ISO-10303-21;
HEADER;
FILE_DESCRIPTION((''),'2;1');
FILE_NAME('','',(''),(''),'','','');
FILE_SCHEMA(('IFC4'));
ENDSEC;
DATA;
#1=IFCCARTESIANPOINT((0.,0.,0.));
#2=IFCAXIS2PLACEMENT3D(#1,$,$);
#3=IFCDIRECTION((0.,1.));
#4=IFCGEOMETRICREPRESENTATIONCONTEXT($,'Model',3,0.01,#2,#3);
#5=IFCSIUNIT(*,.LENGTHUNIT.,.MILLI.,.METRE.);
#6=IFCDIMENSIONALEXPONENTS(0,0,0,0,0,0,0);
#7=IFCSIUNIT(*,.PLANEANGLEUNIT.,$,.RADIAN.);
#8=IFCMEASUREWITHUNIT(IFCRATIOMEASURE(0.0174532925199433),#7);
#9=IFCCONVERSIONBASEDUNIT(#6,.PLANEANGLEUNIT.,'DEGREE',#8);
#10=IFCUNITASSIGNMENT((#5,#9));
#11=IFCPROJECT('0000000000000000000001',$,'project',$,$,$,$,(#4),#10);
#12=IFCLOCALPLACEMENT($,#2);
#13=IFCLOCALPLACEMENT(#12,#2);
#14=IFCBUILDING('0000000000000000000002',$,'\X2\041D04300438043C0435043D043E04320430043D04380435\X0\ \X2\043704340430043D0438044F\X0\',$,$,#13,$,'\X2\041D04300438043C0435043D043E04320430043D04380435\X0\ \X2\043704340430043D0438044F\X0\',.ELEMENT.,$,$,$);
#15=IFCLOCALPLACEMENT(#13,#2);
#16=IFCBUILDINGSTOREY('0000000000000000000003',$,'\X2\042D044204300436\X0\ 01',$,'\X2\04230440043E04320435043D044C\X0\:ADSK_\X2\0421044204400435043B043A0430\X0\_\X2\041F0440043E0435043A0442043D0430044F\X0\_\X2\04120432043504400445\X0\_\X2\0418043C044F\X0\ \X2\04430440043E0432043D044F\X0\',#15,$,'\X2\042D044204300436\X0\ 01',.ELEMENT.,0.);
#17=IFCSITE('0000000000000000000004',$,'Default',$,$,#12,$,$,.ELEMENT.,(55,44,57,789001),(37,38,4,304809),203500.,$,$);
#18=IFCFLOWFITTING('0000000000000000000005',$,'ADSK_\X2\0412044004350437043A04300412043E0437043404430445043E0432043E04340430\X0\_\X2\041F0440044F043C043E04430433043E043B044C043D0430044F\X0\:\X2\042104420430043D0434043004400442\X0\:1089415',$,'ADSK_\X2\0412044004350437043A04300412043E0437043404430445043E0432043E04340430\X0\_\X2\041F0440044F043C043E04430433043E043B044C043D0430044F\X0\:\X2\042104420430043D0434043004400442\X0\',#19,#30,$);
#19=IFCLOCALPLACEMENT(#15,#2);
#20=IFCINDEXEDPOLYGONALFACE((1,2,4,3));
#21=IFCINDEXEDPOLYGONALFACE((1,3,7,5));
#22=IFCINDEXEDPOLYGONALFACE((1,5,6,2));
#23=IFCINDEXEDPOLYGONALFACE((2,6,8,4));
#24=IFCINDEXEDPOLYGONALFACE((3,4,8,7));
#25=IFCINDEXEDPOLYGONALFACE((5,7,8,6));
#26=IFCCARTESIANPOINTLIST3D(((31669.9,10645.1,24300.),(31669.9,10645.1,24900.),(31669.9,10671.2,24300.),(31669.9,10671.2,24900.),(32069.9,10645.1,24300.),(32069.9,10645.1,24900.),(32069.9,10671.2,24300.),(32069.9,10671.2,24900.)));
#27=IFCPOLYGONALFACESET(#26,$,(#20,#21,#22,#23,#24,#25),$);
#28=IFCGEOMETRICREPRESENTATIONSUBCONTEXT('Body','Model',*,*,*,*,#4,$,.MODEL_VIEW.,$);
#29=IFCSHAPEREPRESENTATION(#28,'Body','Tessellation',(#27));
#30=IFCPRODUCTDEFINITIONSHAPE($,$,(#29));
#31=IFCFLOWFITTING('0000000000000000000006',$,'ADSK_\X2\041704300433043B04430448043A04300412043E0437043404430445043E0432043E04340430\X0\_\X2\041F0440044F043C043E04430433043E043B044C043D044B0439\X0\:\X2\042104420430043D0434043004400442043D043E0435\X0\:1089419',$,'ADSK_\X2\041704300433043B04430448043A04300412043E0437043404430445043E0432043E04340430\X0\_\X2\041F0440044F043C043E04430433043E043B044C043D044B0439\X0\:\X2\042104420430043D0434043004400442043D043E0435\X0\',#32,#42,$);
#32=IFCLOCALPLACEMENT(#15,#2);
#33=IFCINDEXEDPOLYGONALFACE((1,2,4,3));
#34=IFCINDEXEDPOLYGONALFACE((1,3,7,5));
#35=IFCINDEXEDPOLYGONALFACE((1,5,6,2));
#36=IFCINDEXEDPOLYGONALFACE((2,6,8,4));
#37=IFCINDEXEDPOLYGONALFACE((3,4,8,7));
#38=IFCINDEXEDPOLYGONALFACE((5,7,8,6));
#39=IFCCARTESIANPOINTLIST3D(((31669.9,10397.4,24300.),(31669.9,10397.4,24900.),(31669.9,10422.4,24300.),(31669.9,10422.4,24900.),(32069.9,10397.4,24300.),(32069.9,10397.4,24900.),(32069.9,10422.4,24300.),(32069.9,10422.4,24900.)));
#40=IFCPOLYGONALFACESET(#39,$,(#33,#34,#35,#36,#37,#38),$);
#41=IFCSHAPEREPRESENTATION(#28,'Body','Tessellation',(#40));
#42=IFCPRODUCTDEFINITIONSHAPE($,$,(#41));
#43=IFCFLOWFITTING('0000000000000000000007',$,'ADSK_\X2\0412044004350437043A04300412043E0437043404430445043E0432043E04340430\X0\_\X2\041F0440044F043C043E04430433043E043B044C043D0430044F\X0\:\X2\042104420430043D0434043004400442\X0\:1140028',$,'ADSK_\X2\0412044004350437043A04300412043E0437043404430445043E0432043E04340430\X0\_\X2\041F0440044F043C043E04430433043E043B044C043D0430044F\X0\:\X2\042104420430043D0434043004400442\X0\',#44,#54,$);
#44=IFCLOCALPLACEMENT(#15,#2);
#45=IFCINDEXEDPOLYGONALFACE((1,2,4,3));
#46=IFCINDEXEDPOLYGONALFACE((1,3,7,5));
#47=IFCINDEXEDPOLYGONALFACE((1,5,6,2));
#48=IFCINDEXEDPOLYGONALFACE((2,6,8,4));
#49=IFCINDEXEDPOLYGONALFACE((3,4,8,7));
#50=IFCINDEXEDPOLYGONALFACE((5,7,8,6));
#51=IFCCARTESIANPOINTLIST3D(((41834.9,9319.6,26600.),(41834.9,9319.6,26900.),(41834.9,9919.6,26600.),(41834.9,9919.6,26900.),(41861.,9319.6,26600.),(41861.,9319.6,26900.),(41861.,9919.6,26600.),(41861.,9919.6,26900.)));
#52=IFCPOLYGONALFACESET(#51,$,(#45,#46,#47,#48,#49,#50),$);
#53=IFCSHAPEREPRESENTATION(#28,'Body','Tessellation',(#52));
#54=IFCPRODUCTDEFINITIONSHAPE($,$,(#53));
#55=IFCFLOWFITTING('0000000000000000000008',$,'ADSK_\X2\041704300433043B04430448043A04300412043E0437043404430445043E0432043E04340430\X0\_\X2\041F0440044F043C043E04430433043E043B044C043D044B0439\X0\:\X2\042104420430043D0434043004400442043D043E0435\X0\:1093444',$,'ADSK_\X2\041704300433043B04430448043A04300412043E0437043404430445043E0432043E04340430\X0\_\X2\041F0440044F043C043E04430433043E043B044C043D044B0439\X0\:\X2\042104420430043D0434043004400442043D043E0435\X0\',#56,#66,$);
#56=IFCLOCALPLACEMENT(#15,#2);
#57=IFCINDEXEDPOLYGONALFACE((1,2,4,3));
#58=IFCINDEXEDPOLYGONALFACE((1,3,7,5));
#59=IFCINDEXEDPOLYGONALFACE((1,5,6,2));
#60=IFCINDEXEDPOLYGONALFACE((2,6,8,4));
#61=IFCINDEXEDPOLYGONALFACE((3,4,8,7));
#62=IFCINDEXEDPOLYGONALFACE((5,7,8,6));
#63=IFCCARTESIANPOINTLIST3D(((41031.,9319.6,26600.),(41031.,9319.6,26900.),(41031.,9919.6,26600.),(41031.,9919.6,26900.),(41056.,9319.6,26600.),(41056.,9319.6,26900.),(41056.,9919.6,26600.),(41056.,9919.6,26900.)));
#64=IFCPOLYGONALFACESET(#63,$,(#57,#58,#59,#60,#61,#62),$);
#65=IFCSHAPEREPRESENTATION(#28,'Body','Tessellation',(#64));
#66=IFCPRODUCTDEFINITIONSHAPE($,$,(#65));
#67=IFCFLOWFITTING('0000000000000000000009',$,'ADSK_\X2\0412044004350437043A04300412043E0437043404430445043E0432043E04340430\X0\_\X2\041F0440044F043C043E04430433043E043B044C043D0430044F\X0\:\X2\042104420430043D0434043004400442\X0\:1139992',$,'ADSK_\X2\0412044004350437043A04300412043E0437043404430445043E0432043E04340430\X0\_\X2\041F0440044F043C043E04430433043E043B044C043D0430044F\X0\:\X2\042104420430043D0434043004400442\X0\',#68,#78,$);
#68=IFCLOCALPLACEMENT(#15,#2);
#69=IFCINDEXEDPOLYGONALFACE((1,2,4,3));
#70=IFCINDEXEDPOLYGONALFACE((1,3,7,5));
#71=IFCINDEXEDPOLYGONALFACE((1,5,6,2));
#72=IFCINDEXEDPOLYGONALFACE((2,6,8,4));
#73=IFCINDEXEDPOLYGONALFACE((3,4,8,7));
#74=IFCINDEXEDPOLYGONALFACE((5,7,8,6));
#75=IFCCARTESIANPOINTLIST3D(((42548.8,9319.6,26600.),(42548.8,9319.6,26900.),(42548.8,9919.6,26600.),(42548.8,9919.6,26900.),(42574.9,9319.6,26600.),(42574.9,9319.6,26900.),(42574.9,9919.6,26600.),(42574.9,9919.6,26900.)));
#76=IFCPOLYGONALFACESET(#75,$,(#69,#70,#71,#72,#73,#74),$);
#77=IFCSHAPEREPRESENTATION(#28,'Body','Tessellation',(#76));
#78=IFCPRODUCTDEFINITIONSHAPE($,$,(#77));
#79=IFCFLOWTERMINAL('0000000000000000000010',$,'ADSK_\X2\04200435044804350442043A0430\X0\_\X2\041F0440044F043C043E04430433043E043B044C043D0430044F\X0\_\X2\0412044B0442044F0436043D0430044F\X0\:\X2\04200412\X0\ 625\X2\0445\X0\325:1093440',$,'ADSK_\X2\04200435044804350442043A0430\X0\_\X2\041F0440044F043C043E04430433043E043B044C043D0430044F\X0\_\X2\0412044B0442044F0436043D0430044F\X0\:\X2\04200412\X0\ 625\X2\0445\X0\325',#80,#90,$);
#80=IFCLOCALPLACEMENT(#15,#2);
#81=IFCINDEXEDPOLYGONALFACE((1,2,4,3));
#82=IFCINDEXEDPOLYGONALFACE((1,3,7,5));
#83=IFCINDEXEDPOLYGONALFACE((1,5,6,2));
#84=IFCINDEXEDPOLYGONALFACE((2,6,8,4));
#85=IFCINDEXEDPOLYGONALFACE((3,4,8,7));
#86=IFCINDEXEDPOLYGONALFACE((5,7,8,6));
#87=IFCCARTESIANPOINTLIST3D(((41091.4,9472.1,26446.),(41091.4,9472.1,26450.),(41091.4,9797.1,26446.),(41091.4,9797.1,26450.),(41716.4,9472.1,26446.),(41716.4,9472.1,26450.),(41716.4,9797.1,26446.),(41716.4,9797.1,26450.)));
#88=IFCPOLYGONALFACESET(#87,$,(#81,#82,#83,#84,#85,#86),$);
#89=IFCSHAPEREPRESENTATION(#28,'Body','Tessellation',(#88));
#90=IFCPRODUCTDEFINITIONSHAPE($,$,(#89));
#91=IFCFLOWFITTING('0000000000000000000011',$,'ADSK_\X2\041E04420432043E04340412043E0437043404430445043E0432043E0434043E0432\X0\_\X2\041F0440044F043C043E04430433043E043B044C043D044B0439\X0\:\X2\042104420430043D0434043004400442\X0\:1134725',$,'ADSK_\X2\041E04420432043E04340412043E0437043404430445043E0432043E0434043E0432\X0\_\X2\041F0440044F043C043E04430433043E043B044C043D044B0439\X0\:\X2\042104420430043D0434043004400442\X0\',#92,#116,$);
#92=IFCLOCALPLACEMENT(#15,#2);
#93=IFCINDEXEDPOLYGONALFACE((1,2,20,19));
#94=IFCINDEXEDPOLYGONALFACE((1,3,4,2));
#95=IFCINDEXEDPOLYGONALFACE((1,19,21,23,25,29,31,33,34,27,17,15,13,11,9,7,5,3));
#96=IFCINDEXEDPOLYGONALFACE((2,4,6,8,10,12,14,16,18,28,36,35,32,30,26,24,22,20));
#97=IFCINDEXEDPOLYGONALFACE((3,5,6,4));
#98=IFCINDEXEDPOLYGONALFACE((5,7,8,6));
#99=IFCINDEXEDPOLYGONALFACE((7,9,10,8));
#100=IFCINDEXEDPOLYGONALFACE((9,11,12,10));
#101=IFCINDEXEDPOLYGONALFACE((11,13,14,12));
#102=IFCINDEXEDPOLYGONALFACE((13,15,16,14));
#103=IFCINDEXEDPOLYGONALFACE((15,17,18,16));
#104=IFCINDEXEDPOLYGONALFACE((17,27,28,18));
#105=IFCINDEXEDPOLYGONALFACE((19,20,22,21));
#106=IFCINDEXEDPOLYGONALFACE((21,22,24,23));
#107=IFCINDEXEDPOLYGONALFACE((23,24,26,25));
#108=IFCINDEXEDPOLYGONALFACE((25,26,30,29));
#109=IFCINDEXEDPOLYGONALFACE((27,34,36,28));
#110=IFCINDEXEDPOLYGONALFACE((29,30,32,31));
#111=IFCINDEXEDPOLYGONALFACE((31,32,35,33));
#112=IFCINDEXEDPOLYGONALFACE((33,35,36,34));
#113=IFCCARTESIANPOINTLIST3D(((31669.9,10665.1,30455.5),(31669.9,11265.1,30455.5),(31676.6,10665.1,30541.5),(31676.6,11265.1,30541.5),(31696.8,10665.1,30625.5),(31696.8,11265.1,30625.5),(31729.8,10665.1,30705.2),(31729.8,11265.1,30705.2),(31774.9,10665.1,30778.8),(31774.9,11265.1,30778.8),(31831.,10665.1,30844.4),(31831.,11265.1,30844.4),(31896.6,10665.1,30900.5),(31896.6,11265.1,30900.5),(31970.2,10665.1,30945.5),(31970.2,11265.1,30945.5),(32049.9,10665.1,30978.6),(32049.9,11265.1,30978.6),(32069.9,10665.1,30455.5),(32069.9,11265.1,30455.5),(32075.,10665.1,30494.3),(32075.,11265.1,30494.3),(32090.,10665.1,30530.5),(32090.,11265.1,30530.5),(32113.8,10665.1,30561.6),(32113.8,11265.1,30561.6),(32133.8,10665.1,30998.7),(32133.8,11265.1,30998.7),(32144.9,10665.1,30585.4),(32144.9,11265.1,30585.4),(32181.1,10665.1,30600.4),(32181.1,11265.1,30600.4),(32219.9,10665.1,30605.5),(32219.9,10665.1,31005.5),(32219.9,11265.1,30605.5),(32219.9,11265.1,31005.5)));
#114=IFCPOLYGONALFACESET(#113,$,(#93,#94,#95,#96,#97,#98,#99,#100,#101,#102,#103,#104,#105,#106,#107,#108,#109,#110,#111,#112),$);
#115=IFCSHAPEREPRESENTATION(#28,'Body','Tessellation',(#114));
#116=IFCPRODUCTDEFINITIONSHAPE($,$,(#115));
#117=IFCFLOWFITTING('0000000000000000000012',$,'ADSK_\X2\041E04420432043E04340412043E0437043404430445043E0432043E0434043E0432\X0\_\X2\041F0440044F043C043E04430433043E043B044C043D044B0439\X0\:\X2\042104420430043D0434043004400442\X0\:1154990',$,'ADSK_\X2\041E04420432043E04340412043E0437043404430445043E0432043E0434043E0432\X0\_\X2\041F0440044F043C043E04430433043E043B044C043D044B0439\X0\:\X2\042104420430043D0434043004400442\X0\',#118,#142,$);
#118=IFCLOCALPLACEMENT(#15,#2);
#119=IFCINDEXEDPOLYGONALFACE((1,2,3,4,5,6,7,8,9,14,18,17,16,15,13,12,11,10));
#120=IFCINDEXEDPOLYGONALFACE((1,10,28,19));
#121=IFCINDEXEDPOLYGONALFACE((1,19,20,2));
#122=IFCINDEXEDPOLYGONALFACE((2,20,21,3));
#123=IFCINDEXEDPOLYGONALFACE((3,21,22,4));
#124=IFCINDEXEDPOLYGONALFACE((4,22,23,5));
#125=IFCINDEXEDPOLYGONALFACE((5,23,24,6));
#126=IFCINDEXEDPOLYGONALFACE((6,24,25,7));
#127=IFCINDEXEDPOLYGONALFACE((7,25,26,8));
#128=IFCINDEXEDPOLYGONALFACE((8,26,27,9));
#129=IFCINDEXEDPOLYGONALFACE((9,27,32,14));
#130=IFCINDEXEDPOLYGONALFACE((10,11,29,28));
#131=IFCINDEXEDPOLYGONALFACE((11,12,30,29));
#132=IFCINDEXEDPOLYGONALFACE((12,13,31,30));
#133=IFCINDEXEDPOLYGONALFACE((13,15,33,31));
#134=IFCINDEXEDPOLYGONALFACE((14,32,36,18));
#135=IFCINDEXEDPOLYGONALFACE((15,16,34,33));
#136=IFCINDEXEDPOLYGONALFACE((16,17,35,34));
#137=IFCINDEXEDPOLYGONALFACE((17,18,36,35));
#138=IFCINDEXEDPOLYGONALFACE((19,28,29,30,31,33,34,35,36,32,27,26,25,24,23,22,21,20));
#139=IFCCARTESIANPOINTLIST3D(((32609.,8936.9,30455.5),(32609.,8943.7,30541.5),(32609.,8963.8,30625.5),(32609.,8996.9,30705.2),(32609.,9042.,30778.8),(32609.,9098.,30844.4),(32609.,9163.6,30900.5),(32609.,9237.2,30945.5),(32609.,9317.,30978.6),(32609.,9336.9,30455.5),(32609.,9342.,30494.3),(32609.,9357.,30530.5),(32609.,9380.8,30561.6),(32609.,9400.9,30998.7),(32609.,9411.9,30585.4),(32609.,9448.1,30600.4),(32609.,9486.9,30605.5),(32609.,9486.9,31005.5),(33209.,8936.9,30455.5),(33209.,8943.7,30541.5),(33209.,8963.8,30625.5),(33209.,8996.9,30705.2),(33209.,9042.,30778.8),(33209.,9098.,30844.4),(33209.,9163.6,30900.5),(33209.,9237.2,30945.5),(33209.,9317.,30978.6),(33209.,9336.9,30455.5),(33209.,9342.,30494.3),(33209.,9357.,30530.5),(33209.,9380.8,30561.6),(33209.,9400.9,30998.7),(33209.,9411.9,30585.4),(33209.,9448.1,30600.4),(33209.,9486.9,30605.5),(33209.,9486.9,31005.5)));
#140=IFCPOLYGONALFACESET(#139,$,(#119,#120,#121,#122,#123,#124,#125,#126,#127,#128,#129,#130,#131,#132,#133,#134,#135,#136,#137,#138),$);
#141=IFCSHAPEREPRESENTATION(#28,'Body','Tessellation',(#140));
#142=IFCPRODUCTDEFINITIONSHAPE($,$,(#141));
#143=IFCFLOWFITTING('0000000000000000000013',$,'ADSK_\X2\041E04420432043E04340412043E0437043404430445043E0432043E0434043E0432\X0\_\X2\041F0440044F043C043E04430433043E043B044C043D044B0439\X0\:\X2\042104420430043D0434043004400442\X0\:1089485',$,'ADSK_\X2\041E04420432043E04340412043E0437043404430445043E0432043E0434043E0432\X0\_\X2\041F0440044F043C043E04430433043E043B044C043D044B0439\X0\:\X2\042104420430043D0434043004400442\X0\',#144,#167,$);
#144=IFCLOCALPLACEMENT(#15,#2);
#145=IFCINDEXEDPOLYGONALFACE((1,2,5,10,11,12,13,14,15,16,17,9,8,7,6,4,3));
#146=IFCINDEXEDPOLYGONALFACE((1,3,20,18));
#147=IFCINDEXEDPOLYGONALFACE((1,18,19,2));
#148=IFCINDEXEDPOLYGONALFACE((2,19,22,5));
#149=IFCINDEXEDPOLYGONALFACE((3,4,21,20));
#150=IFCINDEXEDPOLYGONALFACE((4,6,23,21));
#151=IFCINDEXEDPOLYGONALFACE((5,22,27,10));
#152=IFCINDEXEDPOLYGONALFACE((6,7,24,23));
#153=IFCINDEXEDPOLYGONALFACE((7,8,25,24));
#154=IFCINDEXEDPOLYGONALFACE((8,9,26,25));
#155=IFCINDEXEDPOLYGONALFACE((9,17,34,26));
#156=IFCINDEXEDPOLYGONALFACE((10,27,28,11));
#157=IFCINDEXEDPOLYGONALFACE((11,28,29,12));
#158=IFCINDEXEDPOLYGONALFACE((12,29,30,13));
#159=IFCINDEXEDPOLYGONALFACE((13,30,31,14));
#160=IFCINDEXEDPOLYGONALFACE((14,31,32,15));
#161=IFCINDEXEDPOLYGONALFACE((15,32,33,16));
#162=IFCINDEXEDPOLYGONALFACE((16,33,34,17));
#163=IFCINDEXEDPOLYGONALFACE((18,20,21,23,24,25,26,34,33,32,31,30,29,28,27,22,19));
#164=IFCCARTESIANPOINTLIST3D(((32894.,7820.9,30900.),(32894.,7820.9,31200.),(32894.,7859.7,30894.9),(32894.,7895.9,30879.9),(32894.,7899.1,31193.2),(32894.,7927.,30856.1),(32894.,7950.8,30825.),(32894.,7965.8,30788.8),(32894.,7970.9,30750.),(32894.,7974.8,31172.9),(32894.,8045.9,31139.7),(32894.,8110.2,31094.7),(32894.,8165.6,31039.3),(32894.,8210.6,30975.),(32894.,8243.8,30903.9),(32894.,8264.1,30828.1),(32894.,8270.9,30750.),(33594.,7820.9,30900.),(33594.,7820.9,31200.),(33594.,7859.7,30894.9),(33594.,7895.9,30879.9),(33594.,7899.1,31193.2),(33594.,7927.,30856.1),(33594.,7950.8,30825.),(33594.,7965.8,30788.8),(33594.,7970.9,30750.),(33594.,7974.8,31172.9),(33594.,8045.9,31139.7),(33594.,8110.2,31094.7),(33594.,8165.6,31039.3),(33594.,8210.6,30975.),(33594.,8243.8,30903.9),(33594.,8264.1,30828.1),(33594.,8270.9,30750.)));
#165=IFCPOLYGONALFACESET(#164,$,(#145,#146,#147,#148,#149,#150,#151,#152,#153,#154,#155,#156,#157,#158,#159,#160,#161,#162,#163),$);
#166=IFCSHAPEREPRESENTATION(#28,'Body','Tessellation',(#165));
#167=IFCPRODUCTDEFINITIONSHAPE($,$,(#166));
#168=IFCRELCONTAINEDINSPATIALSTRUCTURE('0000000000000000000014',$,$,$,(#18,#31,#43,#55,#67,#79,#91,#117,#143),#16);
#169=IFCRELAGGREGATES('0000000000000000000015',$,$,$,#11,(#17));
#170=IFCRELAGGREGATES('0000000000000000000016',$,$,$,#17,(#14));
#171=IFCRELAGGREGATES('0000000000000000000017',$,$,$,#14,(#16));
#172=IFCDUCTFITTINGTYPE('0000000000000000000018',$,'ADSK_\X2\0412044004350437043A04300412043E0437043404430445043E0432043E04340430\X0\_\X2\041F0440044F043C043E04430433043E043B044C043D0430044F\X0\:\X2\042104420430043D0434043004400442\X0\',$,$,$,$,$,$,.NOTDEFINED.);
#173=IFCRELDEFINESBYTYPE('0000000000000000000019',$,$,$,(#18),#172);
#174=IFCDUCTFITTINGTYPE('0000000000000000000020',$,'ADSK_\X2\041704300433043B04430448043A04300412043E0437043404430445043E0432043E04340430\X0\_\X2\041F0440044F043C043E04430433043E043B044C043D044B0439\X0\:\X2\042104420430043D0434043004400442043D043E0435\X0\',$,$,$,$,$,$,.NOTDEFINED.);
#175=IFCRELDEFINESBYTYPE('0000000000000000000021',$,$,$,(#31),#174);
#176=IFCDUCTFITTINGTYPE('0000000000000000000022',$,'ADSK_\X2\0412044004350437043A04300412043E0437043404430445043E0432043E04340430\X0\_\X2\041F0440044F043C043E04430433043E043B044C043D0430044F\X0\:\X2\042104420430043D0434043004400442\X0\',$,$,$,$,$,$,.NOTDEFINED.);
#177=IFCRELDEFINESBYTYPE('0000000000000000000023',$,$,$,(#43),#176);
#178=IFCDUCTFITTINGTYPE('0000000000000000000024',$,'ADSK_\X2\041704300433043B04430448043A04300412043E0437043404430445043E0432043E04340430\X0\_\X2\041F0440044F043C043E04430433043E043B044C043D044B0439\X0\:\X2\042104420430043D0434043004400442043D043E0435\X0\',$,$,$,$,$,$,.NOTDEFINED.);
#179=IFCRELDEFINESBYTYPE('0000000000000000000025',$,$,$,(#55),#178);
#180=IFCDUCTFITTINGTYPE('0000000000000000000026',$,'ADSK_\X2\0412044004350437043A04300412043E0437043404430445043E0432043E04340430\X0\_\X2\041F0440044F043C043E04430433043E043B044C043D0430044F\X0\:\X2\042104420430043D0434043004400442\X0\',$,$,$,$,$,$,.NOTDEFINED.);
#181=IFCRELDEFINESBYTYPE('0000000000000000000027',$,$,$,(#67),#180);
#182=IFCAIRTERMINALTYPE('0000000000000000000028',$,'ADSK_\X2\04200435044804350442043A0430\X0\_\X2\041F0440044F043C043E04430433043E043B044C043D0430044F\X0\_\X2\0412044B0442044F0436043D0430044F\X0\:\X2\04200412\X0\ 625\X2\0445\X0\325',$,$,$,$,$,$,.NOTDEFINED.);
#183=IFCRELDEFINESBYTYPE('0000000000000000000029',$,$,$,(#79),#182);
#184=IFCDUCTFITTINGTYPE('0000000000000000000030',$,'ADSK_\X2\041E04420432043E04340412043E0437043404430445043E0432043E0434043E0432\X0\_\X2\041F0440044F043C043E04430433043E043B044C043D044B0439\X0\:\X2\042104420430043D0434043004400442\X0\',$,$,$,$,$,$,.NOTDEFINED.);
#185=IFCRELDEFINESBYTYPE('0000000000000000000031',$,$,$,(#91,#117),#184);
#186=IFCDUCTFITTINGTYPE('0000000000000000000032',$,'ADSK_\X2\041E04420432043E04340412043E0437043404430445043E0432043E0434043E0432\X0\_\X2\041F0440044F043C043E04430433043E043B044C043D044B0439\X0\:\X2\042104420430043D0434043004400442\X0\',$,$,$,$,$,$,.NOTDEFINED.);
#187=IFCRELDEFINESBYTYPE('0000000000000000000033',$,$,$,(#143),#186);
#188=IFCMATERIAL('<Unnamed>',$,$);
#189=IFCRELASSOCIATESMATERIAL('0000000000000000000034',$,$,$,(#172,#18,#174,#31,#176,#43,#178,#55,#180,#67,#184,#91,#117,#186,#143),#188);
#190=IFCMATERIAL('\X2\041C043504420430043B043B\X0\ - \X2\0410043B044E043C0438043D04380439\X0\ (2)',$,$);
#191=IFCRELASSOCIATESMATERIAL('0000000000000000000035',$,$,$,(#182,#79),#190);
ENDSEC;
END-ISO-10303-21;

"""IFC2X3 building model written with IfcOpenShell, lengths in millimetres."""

from ifc_helpers import new_model, entity, si_unit, converted_unit, direction, frame, frame_2d, origin, origin_2d_with_axis, place, context, subcontext, project, spatial, polyline, circle_curve, parameter, trimmed, segment, composite_curve, rectangle, outline, extrude, source, transform, mapped, material, type_object, type_shapes, element, save


model = new_model("IFC2X3")

# Units and contexts
model_context = context("Model", 3, precision=0.01, world=origin(), true_north=direction((0.0, 1.0)))
body_context = subcontext(model_context, "Body", "Model", "MODEL_VIEW")
ifc_project = project(units=[si_unit("LENGTHUNIT", "METRE", prefix="MILLI"), converted_unit("PLANEANGLEUNIT", "DEGREE", entity("IfcRatioMeasure", 0.0174532925199433), si_unit("PLANEANGLEUNIT", "RADIAN"), dimensions=[0, 0, 0, 0, 0, 0, 0])], contexts=[model_context])

# Site, building, storey
site_placement = place(None, frame((0.0, 0.0, 0.0)))
site = spatial("IfcSite", under=ifc_project, at=site_placement, Name="Default", CompositionType="ELEMENT", RefLatitude=(55, 44, 57, 789001), RefLongitude=(37, 38, 4, 304809), RefElevation=203500.0)
building_placement = place(site_placement, origin())
building = spatial("IfcBuilding", under=site, at=building_placement, Name="Наименование здания", LongName="Наименование здания", CompositionType="ELEMENT")
storey_placement = place(building_placement, origin())
storey = spatial("IfcBuildingStorey", under=building, at=storey_placement, Name="Этаж 01", ObjectType="Уровень:ADSK_Стрелка_Проектная_Вверх_Имя уровня", LongName="Этаж 01", CompositionType="ELEMENT", Elevation=0.0)

# Flow fittings
ifc_material_1 = material(Name="<Unnamed>")
duct_fitting_type_1 = type_object("IfcDuctFittingType", Name="ADSK_ВрезкаВоздуховода_Прямоугольная:Стандарт", PredefinedType="NOTDEFINED", material=ifc_material_1)
shared_shape_1 = source(origin(), body_context, "Body", "SweptSolid", [
    extrude(rectangle(XDim=26.1, YDim=600.0, at=frame_2d((0.0, 0.0), x_axis=(1.0, 0.0))), frame((7.0, 0.0, -200.0)), (0.0, 0.0, 1.0), 400.0),
])
type_shapes(duct_fitting_type_1, [shared_shape_1])
flow_fitting_1_placement = place(storey_placement, frame((31869.9, 10665.1, 24600.0), z_axis=(-1.0, 0.0, 0.0), x_axis=(0.0, -1.0, 0.0)))
element("IfcFlowFitting", 1, at=flow_fitting_1_placement, inside=storey, type_object=duct_fitting_type_1, material=ifc_material_1, Name="ADSK_ВрезкаВоздуховода_Прямоугольная:Стандарт:1089415", ObjectType="ADSK_ВрезкаВоздуховода_Прямоугольная:Стандарт", context=body_context, shape_type="MappedRepresentation", body=[
    mapped(shared_shape_1, transform((0.0, 0.0, 0.0), scale=1.0)),
])
duct_fitting_type_2 = type_object("IfcDuctFittingType", Name="ADSK_ЗаглушкаВоздуховода_Прямоугольный:Стандартное", PredefinedType="NOTDEFINED", material=ifc_material_1)
shared_shape_2 = source(origin(), body_context, "Body", "SweptSolid", [
    extrude(rectangle(XDim=25.0, YDim=400.0, at=frame_2d((0.0, 0.0), x_axis=(1.0, 0.0))), frame((12.5, 0.0, -300.0)), (0.0, 0.0, 1.0), 600.0),
])
type_shapes(duct_fitting_type_2, [shared_shape_2])
flow_fitting_2_placement = place(storey_placement, frame((31869.9, 10422.4, 24600.0), z_axis=(0.0, 0.0, 1.0), x_axis=(0.0, -1.0, 0.0)))
element("IfcFlowFitting", 2, at=flow_fitting_2_placement, inside=storey, type_object=duct_fitting_type_2, material=ifc_material_1, Name="ADSK_ЗаглушкаВоздуховода_Прямоугольный:Стандартное:1089419", ObjectType="ADSK_ЗаглушкаВоздуховода_Прямоугольный:Стандартное", context=body_context, shape_type="MappedRepresentation", body=[
    mapped(shared_shape_2, transform((0.0, 0.0, 0.0), scale=1.0)),
])
duct_fitting_type_3 = type_object("IfcDuctFittingType", Name="ADSK_ВрезкаВоздуховода_Прямоугольная:Стандарт", PredefinedType="NOTDEFINED", material=ifc_material_1)
shared_shape_3 = source(origin(), body_context, "Body", "SweptSolid", [
    extrude(rectangle(XDim=26.1, YDim=600.0, at=frame_2d((0.0, 0.0), x_axis=(1.0, 0.0))), frame((7.0, 0.0, -150.0)), (0.0, 0.0, 1.0), 300.0),
])
type_shapes(duct_fitting_type_3, [shared_shape_3])
flow_fitting_3_placement = place(storey_placement, frame((41854.9, 9619.6, 26750.0), z_axis=(0.0, 0.0, -1.0), x_axis=(-1.0, 0.0, 0.0)))
element("IfcFlowFitting", 3, at=flow_fitting_3_placement, inside=storey, type_object=duct_fitting_type_3, material=ifc_material_1, Name="ADSK_ВрезкаВоздуховода_Прямоугольная:Стандарт:1140028", ObjectType="ADSK_ВрезкаВоздуховода_Прямоугольная:Стандарт", context=body_context, shape_type="MappedRepresentation", body=[
    mapped(shared_shape_3, transform((0.0, 0.0, 0.0), scale=1.0)),
])
duct_fitting_type_4 = type_object("IfcDuctFittingType", Name="ADSK_ЗаглушкаВоздуховода_Прямоугольный:Стандартное", PredefinedType="NOTDEFINED", material=ifc_material_1)
shared_shape_4 = source(origin(), body_context, "Body", "SweptSolid", [
    extrude(rectangle(XDim=25.0, YDim=600.0, at=frame_2d((0.0, 0.0), x_axis=(1.0, 0.0))), frame((12.5, 0.0, -150.0)), (0.0, 0.0, 1.0), 300.0),
])
type_shapes(duct_fitting_type_4, [shared_shape_4])
flow_fitting_4_placement = place(storey_placement, frame((41056.0, 9619.6, 26750.0), z_axis=(0.0, 0.0, 1.0), x_axis=(-1.0, 0.0, 0.0)))
element("IfcFlowFitting", 4, at=flow_fitting_4_placement, inside=storey, type_object=duct_fitting_type_4, material=ifc_material_1, Name="ADSK_ЗаглушкаВоздуховода_Прямоугольный:Стандартное:1093444", ObjectType="ADSK_ЗаглушкаВоздуховода_Прямоугольный:Стандартное", context=body_context, shape_type="MappedRepresentation", body=[
    mapped(shared_shape_4, transform((0.0, 0.0, 0.0), scale=1.0)),
])
duct_fitting_type_5 = type_object("IfcDuctFittingType", Name="ADSK_ВрезкаВоздуховода_Прямоугольная:Стандарт", PredefinedType="NOTDEFINED", material=ifc_material_1)
shared_shape_5 = source(origin(), body_context, "Body", "SweptSolid", [
    extrude(rectangle(XDim=600.0, YDim=26.1, at=origin_2d_with_axis()), frame((7.0, 0.0, -150.0), z_axis=(0.0, 0.0, 1.0), x_axis=(0.0, -1.0, 0.0)), (0.0, 0.0, 1.0), 300.0),
])
type_shapes(duct_fitting_type_5, [shared_shape_5])
flow_fitting_5_placement = place(storey_placement, frame((42554.9, 9619.6, 26750.0), z_axis=(0.0, 0.0, -1.0), x_axis=(1.0, 0.0, 0.0)))
element("IfcFlowFitting", 5, at=flow_fitting_5_placement, inside=storey, type_object=duct_fitting_type_5, material=ifc_material_1, Name="ADSK_ВрезкаВоздуховода_Прямоугольная:Стандарт:1139992", ObjectType="ADSK_ВрезкаВоздуховода_Прямоугольная:Стандарт", context=body_context, shape_type="MappedRepresentation", body=[
    mapped(shared_shape_5, transform((0.0, 0.0, 0.0), scale=1.0)),
])

# Flow terminal
ifc_material_2 = material(Name="Металл - Алюминий (2)")
air_terminal_type = type_object("IfcAirTerminalType", Name="ADSK_Решетка_Прямоугольная_Вытяжная:РВ 625х325", PredefinedType="NOTDEFINED", material=ifc_material_2)
shared_shape_6 = source(origin(), body_context, "Body", "SweptSolid", [
    extrude(rectangle(XDim=4.0, YDim=625.0, at=origin_2d_with_axis()), frame((0.0, -2.0, -162.5), z_axis=(0.0, 0.0, 1.0), x_axis=(0.0, 1.0, 0.0)), (0.0, 0.0, 1.0), 325.0),
])
type_shapes(air_terminal_type, [shared_shape_6])
flow_terminal_placement = place(storey_placement, frame((41403.9, 9634.6, 26450.0), z_axis=(0.0, -1.0, 0.0), x_axis=(1.0, 0.0, 0.0)))
element("IfcFlowTerminal", 6, at=flow_terminal_placement, inside=storey, type_object=air_terminal_type, material=ifc_material_2, Name="ADSK_Решетка_Прямоугольная_Вытяжная:РВ 625х325:1093440", ObjectType="ADSK_Решетка_Прямоугольная_Вытяжная:РВ 625х325", context=body_context, shape_type="MappedRepresentation", body=[
    mapped(shared_shape_6, transform((0.0, 0.0, 0.0), scale=1.0)),
])

# Flow fittings
duct_fitting_type_6 = type_object("IfcDuctFittingType", Name="ADSK_ОтводВоздуховодов_Прямоугольный:Стандарт", PredefinedType="NOTDEFINED", material=ifc_material_1)
shared_shape_7 = source(origin(), body_context, "Body", "SweptSolid", [
    extrude(outline(composite_curve([segment(polyline([(-375.0, -175.0), (25.0, -175.0)]), True, "CONTINUOUS"), segment(trimmed(circle_curve(frame_2d((175.0, -175.0), x_axis=(0.0, 1.0)), 150.0), [parameter(0.0)], [parameter(90.0)], True, "PARAMETER"), False, "CONTINUOUS"), segment(polyline([(175.0, -25.0), (175.0, 375.0)]), True, "CONTINUOUS"), segment(trimmed(circle_curve(frame_2d((175.0, -175.0), x_axis=(0.0, 1.0)), 550.0), [parameter(0.0)], [parameter(90.0)], True, "PARAMETER"), True, "CONTINUOUS")], self_intersect=False)), frame((-175.0, 175.0, -300.0), z_axis=(0.0, 0.0, 1.0), x_axis=(-1.0, 0.0, 0.0)), (0.0, 0.0, 1.0), 600.0),
])
type_shapes(duct_fitting_type_6, [shared_shape_7])
for number, where, z_axis, x_axis, name in (
    (7, (31869.9, 10965.1, 30805.5), (0.0, -1.0, 0.0), (-1.0, 0.0, 0.0), "ADSK_ОтводВоздуховодов_Прямоугольный:Стандарт:1134725"),
    (8, (32909.0, 9136.9, 30805.5), (1.0, 0.0, 0.0), (0.0, -1.0, 0.0), "ADSK_ОтводВоздуховодов_Прямоугольный:Стандарт:1154990"),
):
    element("IfcFlowFitting", number, at=place(storey_placement, frame(where, z_axis=z_axis, x_axis=x_axis)), inside=storey, type_object=duct_fitting_type_6, material=ifc_material_1, Name=name, ObjectType="ADSK_ОтводВоздуховодов_Прямоугольный:Стандарт", context=body_context, shape_type="MappedRepresentation", body=[
        mapped(shared_shape_7, transform((0.0, 0.0, 0.0), scale=1.0)),
    ])
duct_fitting_type_7 = type_object("IfcDuctFittingType", Name="ADSK_ОтводВоздуховодов_Прямоугольный:Стандарт", PredefinedType="NOTDEFINED", material=ifc_material_1)
shared_shape_8 = source(origin(), body_context, "Body", "SweptSolid", [
    extrude(outline(composite_curve([segment(polyline([(-300.0, -150.0), (0.0, -150.0)]), True, "CONTINUOUS"), segment(trimmed(circle_curve(frame_2d((150.0, -150.0), x_axis=(0.0, 1.0)), 150.0), [parameter(0.0)], [parameter(90.0)], True, "PARAMETER"), False, "CONTINUOUS"), segment(polyline([(150.0, 0.0), (150.0, 300.0)]), True, "CONTINUOUS"), segment(trimmed(circle_curve(frame_2d((150.0, -150.0), x_axis=(0.0, 1.0)), 450.0), [parameter(0.0)], [parameter(90.0)], True, "PARAMETER"), True, "CONTINUOUS")], self_intersect=False)), frame((-150.0, 150.0, -350.0), z_axis=(0.0, 0.0, 1.0), x_axis=(-1.0, 0.0, 0.0)), (0.0, 0.0, 1.0), 700.0),
])
type_shapes(duct_fitting_type_7, [shared_shape_8])
for number, where, z_axis, x_axis, name in (
    (9, (33244.0, 8120.9, 31050.0), (1.0, 0.0, 0.0), (0.0, 0.0, 1.0), "ADSK_ОтводВоздуховодов_Прямоугольный:Стандарт:1089485"),
):
    element("IfcFlowFitting", number, at=place(storey_placement, frame(where, z_axis=z_axis, x_axis=x_axis)), inside=storey, type_object=duct_fitting_type_7, material=ifc_material_1, Name=name, ObjectType="ADSK_ОтводВоздуховодов_Прямоугольный:Стандарт", context=body_context, shape_type="MappedRepresentation", body=[
        mapped(shared_shape_8, transform((0.0, 0.0, 0.0), scale=1.0)),
    ])

save(model, "model.ifc")
